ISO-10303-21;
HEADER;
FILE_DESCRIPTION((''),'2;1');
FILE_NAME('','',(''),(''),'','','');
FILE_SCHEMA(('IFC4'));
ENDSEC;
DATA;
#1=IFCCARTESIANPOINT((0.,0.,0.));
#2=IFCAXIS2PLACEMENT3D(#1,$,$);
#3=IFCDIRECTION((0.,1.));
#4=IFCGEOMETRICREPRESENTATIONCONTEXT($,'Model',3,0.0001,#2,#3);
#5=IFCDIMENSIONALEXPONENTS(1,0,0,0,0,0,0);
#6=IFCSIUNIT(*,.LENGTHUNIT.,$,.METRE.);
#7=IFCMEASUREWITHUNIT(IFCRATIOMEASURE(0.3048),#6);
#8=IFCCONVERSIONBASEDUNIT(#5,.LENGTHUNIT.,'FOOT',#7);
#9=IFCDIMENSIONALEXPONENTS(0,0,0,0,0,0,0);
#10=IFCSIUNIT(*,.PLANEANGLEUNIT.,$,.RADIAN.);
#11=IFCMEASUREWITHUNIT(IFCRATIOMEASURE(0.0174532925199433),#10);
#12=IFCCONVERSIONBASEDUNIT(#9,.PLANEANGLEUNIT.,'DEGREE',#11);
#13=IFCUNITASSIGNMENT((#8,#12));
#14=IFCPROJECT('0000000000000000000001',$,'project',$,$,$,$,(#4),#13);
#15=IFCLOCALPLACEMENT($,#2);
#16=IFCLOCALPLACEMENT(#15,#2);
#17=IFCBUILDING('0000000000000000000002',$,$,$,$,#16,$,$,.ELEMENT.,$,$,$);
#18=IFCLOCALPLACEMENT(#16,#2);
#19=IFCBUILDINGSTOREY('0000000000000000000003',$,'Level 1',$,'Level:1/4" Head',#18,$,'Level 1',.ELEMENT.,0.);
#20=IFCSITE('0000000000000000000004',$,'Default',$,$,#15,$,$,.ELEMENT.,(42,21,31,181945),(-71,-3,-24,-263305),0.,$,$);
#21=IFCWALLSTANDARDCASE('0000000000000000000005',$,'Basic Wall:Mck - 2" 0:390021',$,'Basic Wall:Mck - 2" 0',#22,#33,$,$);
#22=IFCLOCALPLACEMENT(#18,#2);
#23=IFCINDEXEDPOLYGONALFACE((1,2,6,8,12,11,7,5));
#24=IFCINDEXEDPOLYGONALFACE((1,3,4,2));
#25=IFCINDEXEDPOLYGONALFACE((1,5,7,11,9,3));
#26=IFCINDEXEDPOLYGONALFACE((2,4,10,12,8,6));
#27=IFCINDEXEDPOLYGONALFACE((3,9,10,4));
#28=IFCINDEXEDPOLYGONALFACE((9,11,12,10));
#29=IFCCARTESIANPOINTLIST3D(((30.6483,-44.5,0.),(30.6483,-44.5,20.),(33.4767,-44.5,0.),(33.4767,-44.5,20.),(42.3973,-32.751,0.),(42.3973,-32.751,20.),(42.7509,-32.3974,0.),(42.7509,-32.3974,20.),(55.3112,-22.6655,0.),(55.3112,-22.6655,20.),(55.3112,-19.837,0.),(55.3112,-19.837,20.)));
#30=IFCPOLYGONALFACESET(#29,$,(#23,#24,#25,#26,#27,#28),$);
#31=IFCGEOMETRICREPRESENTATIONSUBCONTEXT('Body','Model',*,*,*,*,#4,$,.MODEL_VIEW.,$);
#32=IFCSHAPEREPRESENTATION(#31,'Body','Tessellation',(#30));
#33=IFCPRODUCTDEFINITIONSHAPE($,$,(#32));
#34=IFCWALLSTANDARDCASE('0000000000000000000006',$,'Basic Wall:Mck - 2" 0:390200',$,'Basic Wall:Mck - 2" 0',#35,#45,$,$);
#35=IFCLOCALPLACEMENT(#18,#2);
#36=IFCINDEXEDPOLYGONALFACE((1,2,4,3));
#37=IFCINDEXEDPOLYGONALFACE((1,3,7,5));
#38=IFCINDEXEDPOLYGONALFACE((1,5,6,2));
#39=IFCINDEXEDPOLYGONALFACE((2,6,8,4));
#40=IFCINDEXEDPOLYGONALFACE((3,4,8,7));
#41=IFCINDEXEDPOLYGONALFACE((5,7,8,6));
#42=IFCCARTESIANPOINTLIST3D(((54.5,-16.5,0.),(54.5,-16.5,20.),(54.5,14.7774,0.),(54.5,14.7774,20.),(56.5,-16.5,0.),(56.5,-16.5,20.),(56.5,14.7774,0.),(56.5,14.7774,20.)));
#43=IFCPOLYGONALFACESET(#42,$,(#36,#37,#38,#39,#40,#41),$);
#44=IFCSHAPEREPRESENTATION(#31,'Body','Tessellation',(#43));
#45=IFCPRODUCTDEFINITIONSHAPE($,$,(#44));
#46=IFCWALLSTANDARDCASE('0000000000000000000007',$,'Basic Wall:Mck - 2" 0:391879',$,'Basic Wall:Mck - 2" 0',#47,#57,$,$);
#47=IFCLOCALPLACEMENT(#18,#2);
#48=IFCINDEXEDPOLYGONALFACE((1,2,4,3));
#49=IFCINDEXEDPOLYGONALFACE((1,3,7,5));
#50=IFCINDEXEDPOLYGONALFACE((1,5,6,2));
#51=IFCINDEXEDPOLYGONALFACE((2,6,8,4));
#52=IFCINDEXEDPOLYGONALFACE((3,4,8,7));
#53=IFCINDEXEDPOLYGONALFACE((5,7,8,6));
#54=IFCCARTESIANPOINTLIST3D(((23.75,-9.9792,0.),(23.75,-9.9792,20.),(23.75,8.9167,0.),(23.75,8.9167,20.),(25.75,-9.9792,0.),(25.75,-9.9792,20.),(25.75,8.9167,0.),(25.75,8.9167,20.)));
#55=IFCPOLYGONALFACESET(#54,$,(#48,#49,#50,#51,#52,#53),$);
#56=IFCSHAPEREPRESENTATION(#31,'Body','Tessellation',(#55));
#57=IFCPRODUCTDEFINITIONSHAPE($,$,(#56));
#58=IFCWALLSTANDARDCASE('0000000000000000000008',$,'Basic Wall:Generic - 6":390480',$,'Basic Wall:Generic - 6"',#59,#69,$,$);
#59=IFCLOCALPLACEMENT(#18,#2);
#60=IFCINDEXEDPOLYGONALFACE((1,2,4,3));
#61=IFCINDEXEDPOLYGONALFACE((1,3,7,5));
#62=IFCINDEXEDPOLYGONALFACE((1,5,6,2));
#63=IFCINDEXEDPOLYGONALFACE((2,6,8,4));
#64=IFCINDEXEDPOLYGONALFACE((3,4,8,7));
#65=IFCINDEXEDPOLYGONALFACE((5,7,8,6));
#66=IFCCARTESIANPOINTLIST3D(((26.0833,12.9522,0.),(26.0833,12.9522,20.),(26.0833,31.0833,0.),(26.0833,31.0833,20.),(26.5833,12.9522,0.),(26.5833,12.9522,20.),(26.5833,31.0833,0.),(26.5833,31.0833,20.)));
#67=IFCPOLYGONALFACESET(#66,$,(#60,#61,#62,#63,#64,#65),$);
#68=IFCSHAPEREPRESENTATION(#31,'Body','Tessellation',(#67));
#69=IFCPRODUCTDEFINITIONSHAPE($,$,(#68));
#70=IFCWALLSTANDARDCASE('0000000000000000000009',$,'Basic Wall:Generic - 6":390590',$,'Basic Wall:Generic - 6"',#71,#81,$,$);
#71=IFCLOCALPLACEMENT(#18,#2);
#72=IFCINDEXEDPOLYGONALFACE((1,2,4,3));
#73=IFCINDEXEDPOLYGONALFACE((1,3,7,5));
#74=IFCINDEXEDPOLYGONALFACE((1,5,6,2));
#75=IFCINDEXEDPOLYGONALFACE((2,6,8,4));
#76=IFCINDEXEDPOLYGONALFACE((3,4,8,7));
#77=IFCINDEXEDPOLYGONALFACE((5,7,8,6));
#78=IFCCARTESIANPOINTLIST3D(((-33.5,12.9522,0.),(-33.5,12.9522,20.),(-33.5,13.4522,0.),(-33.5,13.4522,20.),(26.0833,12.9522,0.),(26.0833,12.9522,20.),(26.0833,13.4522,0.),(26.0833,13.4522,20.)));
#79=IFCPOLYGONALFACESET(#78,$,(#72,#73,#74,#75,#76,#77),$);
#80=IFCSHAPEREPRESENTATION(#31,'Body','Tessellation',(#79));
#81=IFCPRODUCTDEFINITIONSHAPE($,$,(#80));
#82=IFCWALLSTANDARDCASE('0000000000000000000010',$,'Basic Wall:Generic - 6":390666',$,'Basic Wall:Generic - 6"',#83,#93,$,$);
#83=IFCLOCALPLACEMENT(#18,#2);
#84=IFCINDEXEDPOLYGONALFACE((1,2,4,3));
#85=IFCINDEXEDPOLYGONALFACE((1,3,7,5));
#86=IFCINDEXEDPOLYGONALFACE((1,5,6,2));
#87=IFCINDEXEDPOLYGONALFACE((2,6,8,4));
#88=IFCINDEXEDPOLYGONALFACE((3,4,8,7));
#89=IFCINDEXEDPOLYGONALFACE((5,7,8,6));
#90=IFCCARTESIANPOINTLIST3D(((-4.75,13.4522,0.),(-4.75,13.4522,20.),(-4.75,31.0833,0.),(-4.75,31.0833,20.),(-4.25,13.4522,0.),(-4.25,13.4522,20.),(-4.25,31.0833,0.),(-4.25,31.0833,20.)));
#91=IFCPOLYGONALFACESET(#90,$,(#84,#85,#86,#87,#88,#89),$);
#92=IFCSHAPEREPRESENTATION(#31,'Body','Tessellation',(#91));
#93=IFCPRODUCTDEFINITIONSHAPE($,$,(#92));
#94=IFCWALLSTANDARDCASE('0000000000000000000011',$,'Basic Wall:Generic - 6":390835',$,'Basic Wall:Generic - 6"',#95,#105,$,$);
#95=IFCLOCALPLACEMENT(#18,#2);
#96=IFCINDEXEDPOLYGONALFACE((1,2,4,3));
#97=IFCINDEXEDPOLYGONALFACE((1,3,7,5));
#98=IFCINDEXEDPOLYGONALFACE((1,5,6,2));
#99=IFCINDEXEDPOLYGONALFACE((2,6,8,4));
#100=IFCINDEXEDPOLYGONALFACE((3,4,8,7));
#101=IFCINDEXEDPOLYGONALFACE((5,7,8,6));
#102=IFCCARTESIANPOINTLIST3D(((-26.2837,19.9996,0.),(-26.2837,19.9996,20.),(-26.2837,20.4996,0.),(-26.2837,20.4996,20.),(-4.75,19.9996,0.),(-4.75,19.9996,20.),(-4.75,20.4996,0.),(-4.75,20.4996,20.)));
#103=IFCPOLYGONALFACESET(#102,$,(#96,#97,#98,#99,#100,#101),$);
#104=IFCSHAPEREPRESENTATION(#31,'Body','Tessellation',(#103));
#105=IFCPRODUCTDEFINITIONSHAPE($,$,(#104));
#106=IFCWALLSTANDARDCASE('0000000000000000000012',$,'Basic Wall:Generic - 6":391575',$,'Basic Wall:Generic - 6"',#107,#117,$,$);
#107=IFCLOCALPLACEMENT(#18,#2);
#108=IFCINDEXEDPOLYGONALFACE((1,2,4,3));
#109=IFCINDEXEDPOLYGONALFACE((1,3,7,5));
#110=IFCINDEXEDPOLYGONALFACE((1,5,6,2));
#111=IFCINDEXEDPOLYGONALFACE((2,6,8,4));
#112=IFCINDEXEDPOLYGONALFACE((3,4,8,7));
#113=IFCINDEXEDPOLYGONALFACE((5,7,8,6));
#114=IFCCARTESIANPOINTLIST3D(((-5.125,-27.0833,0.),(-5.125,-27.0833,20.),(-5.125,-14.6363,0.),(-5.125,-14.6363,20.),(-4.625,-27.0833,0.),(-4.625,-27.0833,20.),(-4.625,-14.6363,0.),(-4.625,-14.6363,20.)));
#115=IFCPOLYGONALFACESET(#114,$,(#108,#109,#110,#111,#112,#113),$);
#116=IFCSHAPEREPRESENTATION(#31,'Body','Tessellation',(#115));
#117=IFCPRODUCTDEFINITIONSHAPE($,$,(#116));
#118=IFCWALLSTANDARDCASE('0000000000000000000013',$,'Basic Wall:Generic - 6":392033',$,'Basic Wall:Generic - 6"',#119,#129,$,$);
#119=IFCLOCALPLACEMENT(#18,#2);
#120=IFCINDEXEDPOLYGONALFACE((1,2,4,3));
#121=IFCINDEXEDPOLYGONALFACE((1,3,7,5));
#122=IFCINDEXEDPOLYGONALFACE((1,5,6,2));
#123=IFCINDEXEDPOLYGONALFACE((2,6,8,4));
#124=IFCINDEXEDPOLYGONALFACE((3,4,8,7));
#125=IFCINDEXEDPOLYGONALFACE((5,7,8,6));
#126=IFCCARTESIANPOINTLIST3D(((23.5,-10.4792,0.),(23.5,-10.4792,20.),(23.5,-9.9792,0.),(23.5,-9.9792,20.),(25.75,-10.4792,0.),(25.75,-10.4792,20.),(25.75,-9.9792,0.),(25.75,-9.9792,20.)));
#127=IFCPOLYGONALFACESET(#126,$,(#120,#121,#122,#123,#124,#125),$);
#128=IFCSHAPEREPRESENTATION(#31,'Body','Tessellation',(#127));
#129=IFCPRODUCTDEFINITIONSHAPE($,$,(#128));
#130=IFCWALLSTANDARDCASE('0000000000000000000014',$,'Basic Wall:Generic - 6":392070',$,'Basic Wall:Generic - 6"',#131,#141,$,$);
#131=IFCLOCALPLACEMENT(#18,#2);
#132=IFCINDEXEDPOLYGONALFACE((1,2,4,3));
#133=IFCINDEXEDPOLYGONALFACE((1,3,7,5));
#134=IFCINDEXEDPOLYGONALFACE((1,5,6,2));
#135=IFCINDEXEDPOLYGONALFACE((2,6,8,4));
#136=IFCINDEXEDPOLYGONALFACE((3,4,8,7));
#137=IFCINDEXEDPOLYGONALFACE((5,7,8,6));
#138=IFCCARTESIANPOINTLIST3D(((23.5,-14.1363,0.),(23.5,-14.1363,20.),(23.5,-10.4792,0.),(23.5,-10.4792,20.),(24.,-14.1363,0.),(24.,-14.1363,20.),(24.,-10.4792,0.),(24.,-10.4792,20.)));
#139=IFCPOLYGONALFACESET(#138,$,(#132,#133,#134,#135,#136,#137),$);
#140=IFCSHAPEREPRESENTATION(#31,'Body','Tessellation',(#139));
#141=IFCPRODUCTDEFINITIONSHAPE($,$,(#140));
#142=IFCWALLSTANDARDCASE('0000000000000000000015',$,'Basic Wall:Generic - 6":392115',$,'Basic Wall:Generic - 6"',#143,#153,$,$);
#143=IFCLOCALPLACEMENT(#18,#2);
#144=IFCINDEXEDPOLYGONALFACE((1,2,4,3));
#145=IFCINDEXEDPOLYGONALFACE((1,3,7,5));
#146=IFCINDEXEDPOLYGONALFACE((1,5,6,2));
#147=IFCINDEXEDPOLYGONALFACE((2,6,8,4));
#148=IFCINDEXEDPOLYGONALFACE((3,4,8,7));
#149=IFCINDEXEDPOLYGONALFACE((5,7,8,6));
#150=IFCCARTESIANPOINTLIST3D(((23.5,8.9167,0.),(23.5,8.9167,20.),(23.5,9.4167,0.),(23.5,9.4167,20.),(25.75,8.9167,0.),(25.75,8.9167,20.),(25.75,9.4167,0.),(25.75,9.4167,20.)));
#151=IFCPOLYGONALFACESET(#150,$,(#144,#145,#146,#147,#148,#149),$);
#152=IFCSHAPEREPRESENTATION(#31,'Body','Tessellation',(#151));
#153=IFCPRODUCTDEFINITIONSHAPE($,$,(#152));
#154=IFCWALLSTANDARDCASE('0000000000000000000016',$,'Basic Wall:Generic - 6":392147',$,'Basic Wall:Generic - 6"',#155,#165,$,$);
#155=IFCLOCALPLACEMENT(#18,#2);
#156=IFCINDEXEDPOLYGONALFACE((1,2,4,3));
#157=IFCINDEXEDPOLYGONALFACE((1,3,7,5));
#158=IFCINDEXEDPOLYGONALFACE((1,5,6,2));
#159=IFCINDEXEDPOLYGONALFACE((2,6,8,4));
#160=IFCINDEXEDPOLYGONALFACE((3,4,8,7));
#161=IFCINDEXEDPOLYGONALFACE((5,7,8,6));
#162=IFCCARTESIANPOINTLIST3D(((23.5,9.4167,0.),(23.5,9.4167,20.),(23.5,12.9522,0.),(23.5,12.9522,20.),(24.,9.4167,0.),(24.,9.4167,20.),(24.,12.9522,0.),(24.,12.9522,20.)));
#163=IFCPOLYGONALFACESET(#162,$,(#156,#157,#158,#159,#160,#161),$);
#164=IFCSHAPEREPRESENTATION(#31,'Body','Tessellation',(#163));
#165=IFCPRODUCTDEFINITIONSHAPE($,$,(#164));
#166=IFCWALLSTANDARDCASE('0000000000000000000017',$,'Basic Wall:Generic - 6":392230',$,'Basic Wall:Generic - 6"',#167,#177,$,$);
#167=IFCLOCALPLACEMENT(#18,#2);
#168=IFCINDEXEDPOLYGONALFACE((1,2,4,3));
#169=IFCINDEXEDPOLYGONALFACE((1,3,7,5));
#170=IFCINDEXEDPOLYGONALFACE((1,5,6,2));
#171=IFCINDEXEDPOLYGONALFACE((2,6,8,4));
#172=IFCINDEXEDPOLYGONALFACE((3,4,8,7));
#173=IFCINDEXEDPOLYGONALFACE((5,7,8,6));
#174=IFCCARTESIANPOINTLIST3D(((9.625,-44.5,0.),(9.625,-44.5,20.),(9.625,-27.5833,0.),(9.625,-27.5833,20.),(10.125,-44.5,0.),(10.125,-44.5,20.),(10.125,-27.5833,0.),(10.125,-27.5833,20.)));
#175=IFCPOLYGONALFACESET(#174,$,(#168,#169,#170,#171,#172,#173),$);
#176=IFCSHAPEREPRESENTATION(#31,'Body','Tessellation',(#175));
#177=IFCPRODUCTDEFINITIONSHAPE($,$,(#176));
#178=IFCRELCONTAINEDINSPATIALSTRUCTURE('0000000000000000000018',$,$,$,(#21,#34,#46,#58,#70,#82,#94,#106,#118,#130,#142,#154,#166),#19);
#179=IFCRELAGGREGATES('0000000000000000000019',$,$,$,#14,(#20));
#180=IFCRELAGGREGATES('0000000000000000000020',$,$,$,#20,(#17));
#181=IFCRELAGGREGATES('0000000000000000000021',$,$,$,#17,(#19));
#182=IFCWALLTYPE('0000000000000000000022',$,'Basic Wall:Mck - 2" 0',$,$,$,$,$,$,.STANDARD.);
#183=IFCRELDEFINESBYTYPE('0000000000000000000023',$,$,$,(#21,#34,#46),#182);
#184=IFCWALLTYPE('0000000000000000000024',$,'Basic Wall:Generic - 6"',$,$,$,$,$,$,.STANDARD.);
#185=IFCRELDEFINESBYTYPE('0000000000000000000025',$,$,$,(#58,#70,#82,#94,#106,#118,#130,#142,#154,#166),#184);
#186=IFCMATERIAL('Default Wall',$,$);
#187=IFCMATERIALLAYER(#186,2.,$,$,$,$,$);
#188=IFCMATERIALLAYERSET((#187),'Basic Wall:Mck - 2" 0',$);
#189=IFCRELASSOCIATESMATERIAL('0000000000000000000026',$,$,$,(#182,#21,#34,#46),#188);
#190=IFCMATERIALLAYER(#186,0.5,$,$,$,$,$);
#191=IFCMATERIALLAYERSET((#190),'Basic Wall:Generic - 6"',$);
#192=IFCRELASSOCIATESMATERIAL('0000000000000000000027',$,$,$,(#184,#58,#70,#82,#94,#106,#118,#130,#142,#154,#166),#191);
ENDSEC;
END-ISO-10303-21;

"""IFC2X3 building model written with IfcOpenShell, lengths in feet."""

from ifc_helpers import new_model, entity, si_unit, converted_unit, direction, frame, frame_2d, origin, place, context, subcontext, project, spatial, polyline, rectangle, outline, extrude, material, layer, layer_set, layer_usage, type_object, element, save


model = new_model("IFC2X3")

# Units and contexts
model_context = context("Model", 3, precision=0.0001, world=origin(), true_north=direction((0.0, 1.0)))
body_context = subcontext(model_context, "Body", "Model", "MODEL_VIEW")
ifc_project = project(units=[converted_unit("LENGTHUNIT", "FOOT", entity("IfcRatioMeasure", 0.3048), si_unit("LENGTHUNIT", "METRE"), dimensions=[1, 0, 0, 0, 0, 0, 0]), converted_unit("PLANEANGLEUNIT", "DEGREE", entity("IfcRatioMeasure", 0.0174532925199433), si_unit("PLANEANGLEUNIT", "RADIAN"), dimensions=[0, 0, 0, 0, 0, 0, 0])], contexts=[model_context])

# Site, building, storey
site_placement = place(None, origin())
site = spatial("IfcSite", under=ifc_project, at=site_placement, Name="Default", CompositionType="ELEMENT", RefLatitude=(42, 21, 31, 181945), RefLongitude=(-71, -3, -24, -263305), RefElevation=0.0)
building_placement = place(site_placement, origin())
building = spatial("IfcBuilding", under=site, at=building_placement, CompositionType="ELEMENT")
storey_placement = place(building_placement, origin())
storey = spatial("IfcBuildingStorey", under=building, at=storey_placement, Name="Level 1", ObjectType="Level:1/4\" Head", LongName="Level 1", CompositionType="ELEMENT", Elevation=0.0)

# Walls
ifc_material = material(Name="Default Wall")
ifc_layer_1 = layer(ifc_material, 2.0)
ifc_layer_set_1 = layer_set([ifc_layer_1], Name="Basic Wall:Mck - 2\" 0")
ifc_layer_usage_1 = layer_usage(ifc_layer_set_1, "AXIS2", "NEGATIVE", 1.0)
wall_type_1 = type_object("IfcWallType", Name="Basic Wall:Mck - 2\" 0", PredefinedType="STANDARD", material=ifc_layer_set_1)
wall_1_placement = place(storey_placement, frame((31.3554, -45.2071, 0.0), z_axis=(0.0, 0.0, 1.0), x_axis=(0.707107, 0.707107, 0.0)))
element("IfcWallStandardCase", 1, at=wall_1_placement, inside=storey, type_object=wall_type_1, material=ifc_layer_usage_1, Name="Basic Wall:Mck - 2\" 0:390021", ObjectType="Basic Wall:Mck - 2\" 0", context=body_context, shape_type="SweptSolid", body=[
    extrude(outline(polyline([(32.8787, -1.0), (34.8787, 1.0), (17.1157, 1.0), (16.6157, 1.0), (0.0, 1.0), (2.0, -1.0), (32.8787, -1.0)])), origin(), (0.0, 0.0, 1.0), 20.0),
])
ifc_layer_usage_2 = layer_usage(ifc_layer_set_1, "AXIS2", "NEGATIVE", 1.0)
wall_2_placement = place(storey_placement, frame((55.5, -16.5, 0.0), z_axis=(0.0, 0.0, 1.0), x_axis=(0.0, 1.0, 0.0)))
element("IfcWallStandardCase", 2, at=wall_2_placement, inside=storey, type_object=wall_type_1, material=ifc_layer_usage_2, Name="Basic Wall:Mck - 2\" 0:390200", ObjectType="Basic Wall:Mck - 2\" 0", context=body_context, shape_type="SweptSolid", body=[
    extrude(rectangle(XDim=31.2774, YDim=2.0, at=frame_2d((15.6387, 0.0), x_axis=(-1.0, 0.0))), origin(), (0.0, 0.0, 1.0), 20.0),
])
ifc_layer_usage_3 = layer_usage(ifc_layer_set_1, "AXIS2", "NEGATIVE", 1.0)
wall_3_placement = place(storey_placement, frame((24.75, -9.9792, 0.0), z_axis=(0.0, 0.0, 1.0), x_axis=(0.0, 1.0, 0.0)))
element("IfcWallStandardCase", 3, at=wall_3_placement, inside=storey, type_object=wall_type_1, material=ifc_layer_usage_3, Name="Basic Wall:Mck - 2\" 0:391879", ObjectType="Basic Wall:Mck - 2\" 0", context=body_context, shape_type="SweptSolid", body=[
    extrude(rectangle(XDim=18.8958, YDim=2.0, at=frame_2d((9.4479, 0.0), x_axis=(-1.0, 0.0))), origin(), (0.0, 0.0, 1.0), 20.0),
])
ifc_layer_2 = layer(ifc_material, 0.5)
ifc_layer_set_2 = layer_set([ifc_layer_2], Name="Basic Wall:Generic - 6\"")
ifc_layer_usage_4 = layer_usage(ifc_layer_set_2, "AXIS2", "NEGATIVE", 0.25)
wall_type_2 = type_object("IfcWallType", Name="Basic Wall:Generic - 6\"", PredefinedType="STANDARD", material=ifc_layer_set_2)
wall_4_placement = place(storey_placement, frame((26.3333, 31.0833, 0.0), z_axis=(0.0, 0.0, 1.0), x_axis=(0.0, -1.0, 0.0)))
element("IfcWallStandardCase", 4, at=wall_4_placement, inside=storey, type_object=wall_type_2, material=ifc_layer_usage_4, Name="Basic Wall:Generic - 6\":390480", ObjectType="Basic Wall:Generic - 6\"", context=body_context, shape_type="SweptSolid", body=[
    extrude(rectangle(XDim=18.1311, YDim=0.5, at=frame_2d((9.0656, 0.0), x_axis=(-1.0, 0.0))), origin(), (0.0, 0.0, 1.0), 20.0),
])
ifc_layer_usage_5 = layer_usage(ifc_layer_set_2, "AXIS2", "NEGATIVE", 0.25)
wall_5_placement = place(storey_placement, frame((26.0833, 13.2022, 0.0), z_axis=(0.0, 0.0, 1.0), x_axis=(-1.0, 0.0, 0.0)))
element("IfcWallStandardCase", 5, at=wall_5_placement, inside=storey, type_object=wall_type_2, material=ifc_layer_usage_5, Name="Basic Wall:Generic - 6\":390590", ObjectType="Basic Wall:Generic - 6\"", context=body_context, shape_type="SweptSolid", body=[
    extrude(rectangle(XDim=59.5833, YDim=0.5, at=frame_2d((29.7917, 0.0), x_axis=(-1.0, 0.0))), origin(), (0.0, 0.0, 1.0), 20.0),
])
ifc_layer_usage_6 = layer_usage(ifc_layer_set_2, "AXIS2", "NEGATIVE", 0.25)
wall_6_placement = place(storey_placement, frame((-4.5, 31.0833, 0.0), z_axis=(0.0, 0.0, 1.0), x_axis=(0.0, -1.0, 0.0)))
element("IfcWallStandardCase", 6, at=wall_6_placement, inside=storey, type_object=wall_type_2, material=ifc_layer_usage_6, Name="Basic Wall:Generic - 6\":390666", ObjectType="Basic Wall:Generic - 6\"", context=body_context, shape_type="SweptSolid", body=[
    extrude(rectangle(XDim=17.6311, YDim=0.5, at=frame_2d((8.8156, 0.0), x_axis=(-1.0, 0.0))), origin(), (0.0, 0.0, 1.0), 20.0),
])
ifc_layer_usage_7 = layer_usage(ifc_layer_set_2, "AXIS2", "NEGATIVE", 0.25)
wall_7_placement = place(storey_placement, frame((-4.75, 20.2496, 0.0), z_axis=(0.0, 0.0, 1.0), x_axis=(-1.0, 0.0, 0.0)))
element("IfcWallStandardCase", 7, at=wall_7_placement, inside=storey, type_object=wall_type_2, material=ifc_layer_usage_7, Name="Basic Wall:Generic - 6\":390835", ObjectType="Basic Wall:Generic - 6\"", context=body_context, shape_type="SweptSolid", body=[
    extrude(rectangle(XDim=21.5337, YDim=0.5, at=frame_2d((10.7668, 0.0), x_axis=(-1.0, 0.0))), origin(), (0.0, 0.0, 1.0), 20.0),
])
ifc_layer_usage_8 = layer_usage(ifc_layer_set_2, "AXIS2", "NEGATIVE", 0.25)
wall_8_placement = place(storey_placement, frame((-4.875, -14.6363, 0.0), z_axis=(0.0, 0.0, 1.0), x_axis=(0.0, -1.0, 0.0)))
element("IfcWallStandardCase", 8, at=wall_8_placement, inside=storey, type_object=wall_type_2, material=ifc_layer_usage_8, Name="Basic Wall:Generic - 6\":391575", ObjectType="Basic Wall:Generic - 6\"", context=body_context, shape_type="SweptSolid", body=[
    extrude(rectangle(XDim=12.447, YDim=0.5, at=frame_2d((6.2235, 0.0), x_axis=(-1.0, 0.0))), origin(), (0.0, 0.0, 1.0), 20.0),
])
ifc_layer_usage_9 = layer_usage(ifc_layer_set_2, "AXIS2", "NEGATIVE", 0.25)
wall_9_placement = place(storey_placement, frame((25.75, -10.2292, 0.0), z_axis=(0.0, 0.0, 1.0), x_axis=(-1.0, 0.0, 0.0)))
element("IfcWallStandardCase", 9, at=wall_9_placement, inside=storey, type_object=wall_type_2, material=ifc_layer_usage_9, Name="Basic Wall:Generic - 6\":392033", ObjectType="Basic Wall:Generic - 6\"", context=body_context, shape_type="SweptSolid", body=[
    extrude(rectangle(XDim=2.25, YDim=0.5, at=frame_2d((1.125, 0.0), x_axis=(-1.0, 0.0))), origin(), (0.0, 0.0, 1.0), 20.0),
])
ifc_layer_usage_10 = layer_usage(ifc_layer_set_2, "AXIS2", "NEGATIVE", 0.25)
wall_10_placement = place(storey_placement, frame((23.75, -10.4792, 0.0), z_axis=(0.0, 0.0, 1.0), x_axis=(0.0, -1.0, 0.0)))
element("IfcWallStandardCase", 10, at=wall_10_placement, inside=storey, type_object=wall_type_2, material=ifc_layer_usage_10, Name="Basic Wall:Generic - 6\":392070", ObjectType="Basic Wall:Generic - 6\"", context=body_context, shape_type="SweptSolid", body=[
    extrude(rectangle(XDim=3.6571, YDim=0.5, at=frame_2d((1.8286, 0.0), x_axis=(-1.0, 0.0))), origin(), (0.0, 0.0, 1.0), 20.0),
])
ifc_layer_usage_11 = layer_usage(ifc_layer_set_2, "AXIS2", "NEGATIVE", 0.25)
wall_11_placement = place(storey_placement, frame((25.75, 9.1667, 0.0), z_axis=(0.0, 0.0, 1.0), x_axis=(-1.0, 0.0, 0.0)))
element("IfcWallStandardCase", 11, at=wall_11_placement, inside=storey, type_object=wall_type_2, material=ifc_layer_usage_11, Name="Basic Wall:Generic - 6\":392115", ObjectType="Basic Wall:Generic - 6\"", context=body_context, shape_type="SweptSolid", body=[
    extrude(rectangle(XDim=2.25, YDim=0.5, at=frame_2d((1.125, 0.0), x_axis=(-1.0, 0.0))), origin(), (0.0, 0.0, 1.0), 20.0),
])
ifc_layer_usage_12 = layer_usage(ifc_layer_set_2, "AXIS2", "NEGATIVE", 0.25)
wall_12_placement = place(storey_placement, frame((23.75, 9.4167, 0.0), z_axis=(0.0, 0.0, 1.0), x_axis=(0.0, 1.0, 0.0)))
element("IfcWallStandardCase", 12, at=wall_12_placement, inside=storey, type_object=wall_type_2, material=ifc_layer_usage_12, Name="Basic Wall:Generic - 6\":392147", ObjectType="Basic Wall:Generic - 6\"", context=body_context, shape_type="SweptSolid", body=[
    extrude(rectangle(XDim=3.5356, YDim=0.5, at=frame_2d((1.7678, 0.0), x_axis=(-1.0, 0.0))), origin(), (0.0, 0.0, 1.0), 20.0),
])
ifc_layer_usage_13 = layer_usage(ifc_layer_set_2, "AXIS2", "NEGATIVE", 0.25)
wall_13_placement = place(storey_placement, frame((9.875, -27.5833, 0.0), z_axis=(0.0, 0.0, 1.0), x_axis=(0.0, -1.0, 0.0)))
element("IfcWallStandardCase", 13, at=wall_13_placement, inside=storey, type_object=wall_type_2, material=ifc_layer_usage_13, Name="Basic Wall:Generic - 6\":392230", ObjectType="Basic Wall:Generic - 6\"", context=body_context, shape_type="SweptSolid", body=[
    extrude(rectangle(XDim=16.9167, YDim=0.5, at=frame_2d((8.4583, 0.0), x_axis=(-1.0, 0.0))), origin(), (0.0, 0.0, 1.0), 20.0),
])

save(model, "model.ifc")
